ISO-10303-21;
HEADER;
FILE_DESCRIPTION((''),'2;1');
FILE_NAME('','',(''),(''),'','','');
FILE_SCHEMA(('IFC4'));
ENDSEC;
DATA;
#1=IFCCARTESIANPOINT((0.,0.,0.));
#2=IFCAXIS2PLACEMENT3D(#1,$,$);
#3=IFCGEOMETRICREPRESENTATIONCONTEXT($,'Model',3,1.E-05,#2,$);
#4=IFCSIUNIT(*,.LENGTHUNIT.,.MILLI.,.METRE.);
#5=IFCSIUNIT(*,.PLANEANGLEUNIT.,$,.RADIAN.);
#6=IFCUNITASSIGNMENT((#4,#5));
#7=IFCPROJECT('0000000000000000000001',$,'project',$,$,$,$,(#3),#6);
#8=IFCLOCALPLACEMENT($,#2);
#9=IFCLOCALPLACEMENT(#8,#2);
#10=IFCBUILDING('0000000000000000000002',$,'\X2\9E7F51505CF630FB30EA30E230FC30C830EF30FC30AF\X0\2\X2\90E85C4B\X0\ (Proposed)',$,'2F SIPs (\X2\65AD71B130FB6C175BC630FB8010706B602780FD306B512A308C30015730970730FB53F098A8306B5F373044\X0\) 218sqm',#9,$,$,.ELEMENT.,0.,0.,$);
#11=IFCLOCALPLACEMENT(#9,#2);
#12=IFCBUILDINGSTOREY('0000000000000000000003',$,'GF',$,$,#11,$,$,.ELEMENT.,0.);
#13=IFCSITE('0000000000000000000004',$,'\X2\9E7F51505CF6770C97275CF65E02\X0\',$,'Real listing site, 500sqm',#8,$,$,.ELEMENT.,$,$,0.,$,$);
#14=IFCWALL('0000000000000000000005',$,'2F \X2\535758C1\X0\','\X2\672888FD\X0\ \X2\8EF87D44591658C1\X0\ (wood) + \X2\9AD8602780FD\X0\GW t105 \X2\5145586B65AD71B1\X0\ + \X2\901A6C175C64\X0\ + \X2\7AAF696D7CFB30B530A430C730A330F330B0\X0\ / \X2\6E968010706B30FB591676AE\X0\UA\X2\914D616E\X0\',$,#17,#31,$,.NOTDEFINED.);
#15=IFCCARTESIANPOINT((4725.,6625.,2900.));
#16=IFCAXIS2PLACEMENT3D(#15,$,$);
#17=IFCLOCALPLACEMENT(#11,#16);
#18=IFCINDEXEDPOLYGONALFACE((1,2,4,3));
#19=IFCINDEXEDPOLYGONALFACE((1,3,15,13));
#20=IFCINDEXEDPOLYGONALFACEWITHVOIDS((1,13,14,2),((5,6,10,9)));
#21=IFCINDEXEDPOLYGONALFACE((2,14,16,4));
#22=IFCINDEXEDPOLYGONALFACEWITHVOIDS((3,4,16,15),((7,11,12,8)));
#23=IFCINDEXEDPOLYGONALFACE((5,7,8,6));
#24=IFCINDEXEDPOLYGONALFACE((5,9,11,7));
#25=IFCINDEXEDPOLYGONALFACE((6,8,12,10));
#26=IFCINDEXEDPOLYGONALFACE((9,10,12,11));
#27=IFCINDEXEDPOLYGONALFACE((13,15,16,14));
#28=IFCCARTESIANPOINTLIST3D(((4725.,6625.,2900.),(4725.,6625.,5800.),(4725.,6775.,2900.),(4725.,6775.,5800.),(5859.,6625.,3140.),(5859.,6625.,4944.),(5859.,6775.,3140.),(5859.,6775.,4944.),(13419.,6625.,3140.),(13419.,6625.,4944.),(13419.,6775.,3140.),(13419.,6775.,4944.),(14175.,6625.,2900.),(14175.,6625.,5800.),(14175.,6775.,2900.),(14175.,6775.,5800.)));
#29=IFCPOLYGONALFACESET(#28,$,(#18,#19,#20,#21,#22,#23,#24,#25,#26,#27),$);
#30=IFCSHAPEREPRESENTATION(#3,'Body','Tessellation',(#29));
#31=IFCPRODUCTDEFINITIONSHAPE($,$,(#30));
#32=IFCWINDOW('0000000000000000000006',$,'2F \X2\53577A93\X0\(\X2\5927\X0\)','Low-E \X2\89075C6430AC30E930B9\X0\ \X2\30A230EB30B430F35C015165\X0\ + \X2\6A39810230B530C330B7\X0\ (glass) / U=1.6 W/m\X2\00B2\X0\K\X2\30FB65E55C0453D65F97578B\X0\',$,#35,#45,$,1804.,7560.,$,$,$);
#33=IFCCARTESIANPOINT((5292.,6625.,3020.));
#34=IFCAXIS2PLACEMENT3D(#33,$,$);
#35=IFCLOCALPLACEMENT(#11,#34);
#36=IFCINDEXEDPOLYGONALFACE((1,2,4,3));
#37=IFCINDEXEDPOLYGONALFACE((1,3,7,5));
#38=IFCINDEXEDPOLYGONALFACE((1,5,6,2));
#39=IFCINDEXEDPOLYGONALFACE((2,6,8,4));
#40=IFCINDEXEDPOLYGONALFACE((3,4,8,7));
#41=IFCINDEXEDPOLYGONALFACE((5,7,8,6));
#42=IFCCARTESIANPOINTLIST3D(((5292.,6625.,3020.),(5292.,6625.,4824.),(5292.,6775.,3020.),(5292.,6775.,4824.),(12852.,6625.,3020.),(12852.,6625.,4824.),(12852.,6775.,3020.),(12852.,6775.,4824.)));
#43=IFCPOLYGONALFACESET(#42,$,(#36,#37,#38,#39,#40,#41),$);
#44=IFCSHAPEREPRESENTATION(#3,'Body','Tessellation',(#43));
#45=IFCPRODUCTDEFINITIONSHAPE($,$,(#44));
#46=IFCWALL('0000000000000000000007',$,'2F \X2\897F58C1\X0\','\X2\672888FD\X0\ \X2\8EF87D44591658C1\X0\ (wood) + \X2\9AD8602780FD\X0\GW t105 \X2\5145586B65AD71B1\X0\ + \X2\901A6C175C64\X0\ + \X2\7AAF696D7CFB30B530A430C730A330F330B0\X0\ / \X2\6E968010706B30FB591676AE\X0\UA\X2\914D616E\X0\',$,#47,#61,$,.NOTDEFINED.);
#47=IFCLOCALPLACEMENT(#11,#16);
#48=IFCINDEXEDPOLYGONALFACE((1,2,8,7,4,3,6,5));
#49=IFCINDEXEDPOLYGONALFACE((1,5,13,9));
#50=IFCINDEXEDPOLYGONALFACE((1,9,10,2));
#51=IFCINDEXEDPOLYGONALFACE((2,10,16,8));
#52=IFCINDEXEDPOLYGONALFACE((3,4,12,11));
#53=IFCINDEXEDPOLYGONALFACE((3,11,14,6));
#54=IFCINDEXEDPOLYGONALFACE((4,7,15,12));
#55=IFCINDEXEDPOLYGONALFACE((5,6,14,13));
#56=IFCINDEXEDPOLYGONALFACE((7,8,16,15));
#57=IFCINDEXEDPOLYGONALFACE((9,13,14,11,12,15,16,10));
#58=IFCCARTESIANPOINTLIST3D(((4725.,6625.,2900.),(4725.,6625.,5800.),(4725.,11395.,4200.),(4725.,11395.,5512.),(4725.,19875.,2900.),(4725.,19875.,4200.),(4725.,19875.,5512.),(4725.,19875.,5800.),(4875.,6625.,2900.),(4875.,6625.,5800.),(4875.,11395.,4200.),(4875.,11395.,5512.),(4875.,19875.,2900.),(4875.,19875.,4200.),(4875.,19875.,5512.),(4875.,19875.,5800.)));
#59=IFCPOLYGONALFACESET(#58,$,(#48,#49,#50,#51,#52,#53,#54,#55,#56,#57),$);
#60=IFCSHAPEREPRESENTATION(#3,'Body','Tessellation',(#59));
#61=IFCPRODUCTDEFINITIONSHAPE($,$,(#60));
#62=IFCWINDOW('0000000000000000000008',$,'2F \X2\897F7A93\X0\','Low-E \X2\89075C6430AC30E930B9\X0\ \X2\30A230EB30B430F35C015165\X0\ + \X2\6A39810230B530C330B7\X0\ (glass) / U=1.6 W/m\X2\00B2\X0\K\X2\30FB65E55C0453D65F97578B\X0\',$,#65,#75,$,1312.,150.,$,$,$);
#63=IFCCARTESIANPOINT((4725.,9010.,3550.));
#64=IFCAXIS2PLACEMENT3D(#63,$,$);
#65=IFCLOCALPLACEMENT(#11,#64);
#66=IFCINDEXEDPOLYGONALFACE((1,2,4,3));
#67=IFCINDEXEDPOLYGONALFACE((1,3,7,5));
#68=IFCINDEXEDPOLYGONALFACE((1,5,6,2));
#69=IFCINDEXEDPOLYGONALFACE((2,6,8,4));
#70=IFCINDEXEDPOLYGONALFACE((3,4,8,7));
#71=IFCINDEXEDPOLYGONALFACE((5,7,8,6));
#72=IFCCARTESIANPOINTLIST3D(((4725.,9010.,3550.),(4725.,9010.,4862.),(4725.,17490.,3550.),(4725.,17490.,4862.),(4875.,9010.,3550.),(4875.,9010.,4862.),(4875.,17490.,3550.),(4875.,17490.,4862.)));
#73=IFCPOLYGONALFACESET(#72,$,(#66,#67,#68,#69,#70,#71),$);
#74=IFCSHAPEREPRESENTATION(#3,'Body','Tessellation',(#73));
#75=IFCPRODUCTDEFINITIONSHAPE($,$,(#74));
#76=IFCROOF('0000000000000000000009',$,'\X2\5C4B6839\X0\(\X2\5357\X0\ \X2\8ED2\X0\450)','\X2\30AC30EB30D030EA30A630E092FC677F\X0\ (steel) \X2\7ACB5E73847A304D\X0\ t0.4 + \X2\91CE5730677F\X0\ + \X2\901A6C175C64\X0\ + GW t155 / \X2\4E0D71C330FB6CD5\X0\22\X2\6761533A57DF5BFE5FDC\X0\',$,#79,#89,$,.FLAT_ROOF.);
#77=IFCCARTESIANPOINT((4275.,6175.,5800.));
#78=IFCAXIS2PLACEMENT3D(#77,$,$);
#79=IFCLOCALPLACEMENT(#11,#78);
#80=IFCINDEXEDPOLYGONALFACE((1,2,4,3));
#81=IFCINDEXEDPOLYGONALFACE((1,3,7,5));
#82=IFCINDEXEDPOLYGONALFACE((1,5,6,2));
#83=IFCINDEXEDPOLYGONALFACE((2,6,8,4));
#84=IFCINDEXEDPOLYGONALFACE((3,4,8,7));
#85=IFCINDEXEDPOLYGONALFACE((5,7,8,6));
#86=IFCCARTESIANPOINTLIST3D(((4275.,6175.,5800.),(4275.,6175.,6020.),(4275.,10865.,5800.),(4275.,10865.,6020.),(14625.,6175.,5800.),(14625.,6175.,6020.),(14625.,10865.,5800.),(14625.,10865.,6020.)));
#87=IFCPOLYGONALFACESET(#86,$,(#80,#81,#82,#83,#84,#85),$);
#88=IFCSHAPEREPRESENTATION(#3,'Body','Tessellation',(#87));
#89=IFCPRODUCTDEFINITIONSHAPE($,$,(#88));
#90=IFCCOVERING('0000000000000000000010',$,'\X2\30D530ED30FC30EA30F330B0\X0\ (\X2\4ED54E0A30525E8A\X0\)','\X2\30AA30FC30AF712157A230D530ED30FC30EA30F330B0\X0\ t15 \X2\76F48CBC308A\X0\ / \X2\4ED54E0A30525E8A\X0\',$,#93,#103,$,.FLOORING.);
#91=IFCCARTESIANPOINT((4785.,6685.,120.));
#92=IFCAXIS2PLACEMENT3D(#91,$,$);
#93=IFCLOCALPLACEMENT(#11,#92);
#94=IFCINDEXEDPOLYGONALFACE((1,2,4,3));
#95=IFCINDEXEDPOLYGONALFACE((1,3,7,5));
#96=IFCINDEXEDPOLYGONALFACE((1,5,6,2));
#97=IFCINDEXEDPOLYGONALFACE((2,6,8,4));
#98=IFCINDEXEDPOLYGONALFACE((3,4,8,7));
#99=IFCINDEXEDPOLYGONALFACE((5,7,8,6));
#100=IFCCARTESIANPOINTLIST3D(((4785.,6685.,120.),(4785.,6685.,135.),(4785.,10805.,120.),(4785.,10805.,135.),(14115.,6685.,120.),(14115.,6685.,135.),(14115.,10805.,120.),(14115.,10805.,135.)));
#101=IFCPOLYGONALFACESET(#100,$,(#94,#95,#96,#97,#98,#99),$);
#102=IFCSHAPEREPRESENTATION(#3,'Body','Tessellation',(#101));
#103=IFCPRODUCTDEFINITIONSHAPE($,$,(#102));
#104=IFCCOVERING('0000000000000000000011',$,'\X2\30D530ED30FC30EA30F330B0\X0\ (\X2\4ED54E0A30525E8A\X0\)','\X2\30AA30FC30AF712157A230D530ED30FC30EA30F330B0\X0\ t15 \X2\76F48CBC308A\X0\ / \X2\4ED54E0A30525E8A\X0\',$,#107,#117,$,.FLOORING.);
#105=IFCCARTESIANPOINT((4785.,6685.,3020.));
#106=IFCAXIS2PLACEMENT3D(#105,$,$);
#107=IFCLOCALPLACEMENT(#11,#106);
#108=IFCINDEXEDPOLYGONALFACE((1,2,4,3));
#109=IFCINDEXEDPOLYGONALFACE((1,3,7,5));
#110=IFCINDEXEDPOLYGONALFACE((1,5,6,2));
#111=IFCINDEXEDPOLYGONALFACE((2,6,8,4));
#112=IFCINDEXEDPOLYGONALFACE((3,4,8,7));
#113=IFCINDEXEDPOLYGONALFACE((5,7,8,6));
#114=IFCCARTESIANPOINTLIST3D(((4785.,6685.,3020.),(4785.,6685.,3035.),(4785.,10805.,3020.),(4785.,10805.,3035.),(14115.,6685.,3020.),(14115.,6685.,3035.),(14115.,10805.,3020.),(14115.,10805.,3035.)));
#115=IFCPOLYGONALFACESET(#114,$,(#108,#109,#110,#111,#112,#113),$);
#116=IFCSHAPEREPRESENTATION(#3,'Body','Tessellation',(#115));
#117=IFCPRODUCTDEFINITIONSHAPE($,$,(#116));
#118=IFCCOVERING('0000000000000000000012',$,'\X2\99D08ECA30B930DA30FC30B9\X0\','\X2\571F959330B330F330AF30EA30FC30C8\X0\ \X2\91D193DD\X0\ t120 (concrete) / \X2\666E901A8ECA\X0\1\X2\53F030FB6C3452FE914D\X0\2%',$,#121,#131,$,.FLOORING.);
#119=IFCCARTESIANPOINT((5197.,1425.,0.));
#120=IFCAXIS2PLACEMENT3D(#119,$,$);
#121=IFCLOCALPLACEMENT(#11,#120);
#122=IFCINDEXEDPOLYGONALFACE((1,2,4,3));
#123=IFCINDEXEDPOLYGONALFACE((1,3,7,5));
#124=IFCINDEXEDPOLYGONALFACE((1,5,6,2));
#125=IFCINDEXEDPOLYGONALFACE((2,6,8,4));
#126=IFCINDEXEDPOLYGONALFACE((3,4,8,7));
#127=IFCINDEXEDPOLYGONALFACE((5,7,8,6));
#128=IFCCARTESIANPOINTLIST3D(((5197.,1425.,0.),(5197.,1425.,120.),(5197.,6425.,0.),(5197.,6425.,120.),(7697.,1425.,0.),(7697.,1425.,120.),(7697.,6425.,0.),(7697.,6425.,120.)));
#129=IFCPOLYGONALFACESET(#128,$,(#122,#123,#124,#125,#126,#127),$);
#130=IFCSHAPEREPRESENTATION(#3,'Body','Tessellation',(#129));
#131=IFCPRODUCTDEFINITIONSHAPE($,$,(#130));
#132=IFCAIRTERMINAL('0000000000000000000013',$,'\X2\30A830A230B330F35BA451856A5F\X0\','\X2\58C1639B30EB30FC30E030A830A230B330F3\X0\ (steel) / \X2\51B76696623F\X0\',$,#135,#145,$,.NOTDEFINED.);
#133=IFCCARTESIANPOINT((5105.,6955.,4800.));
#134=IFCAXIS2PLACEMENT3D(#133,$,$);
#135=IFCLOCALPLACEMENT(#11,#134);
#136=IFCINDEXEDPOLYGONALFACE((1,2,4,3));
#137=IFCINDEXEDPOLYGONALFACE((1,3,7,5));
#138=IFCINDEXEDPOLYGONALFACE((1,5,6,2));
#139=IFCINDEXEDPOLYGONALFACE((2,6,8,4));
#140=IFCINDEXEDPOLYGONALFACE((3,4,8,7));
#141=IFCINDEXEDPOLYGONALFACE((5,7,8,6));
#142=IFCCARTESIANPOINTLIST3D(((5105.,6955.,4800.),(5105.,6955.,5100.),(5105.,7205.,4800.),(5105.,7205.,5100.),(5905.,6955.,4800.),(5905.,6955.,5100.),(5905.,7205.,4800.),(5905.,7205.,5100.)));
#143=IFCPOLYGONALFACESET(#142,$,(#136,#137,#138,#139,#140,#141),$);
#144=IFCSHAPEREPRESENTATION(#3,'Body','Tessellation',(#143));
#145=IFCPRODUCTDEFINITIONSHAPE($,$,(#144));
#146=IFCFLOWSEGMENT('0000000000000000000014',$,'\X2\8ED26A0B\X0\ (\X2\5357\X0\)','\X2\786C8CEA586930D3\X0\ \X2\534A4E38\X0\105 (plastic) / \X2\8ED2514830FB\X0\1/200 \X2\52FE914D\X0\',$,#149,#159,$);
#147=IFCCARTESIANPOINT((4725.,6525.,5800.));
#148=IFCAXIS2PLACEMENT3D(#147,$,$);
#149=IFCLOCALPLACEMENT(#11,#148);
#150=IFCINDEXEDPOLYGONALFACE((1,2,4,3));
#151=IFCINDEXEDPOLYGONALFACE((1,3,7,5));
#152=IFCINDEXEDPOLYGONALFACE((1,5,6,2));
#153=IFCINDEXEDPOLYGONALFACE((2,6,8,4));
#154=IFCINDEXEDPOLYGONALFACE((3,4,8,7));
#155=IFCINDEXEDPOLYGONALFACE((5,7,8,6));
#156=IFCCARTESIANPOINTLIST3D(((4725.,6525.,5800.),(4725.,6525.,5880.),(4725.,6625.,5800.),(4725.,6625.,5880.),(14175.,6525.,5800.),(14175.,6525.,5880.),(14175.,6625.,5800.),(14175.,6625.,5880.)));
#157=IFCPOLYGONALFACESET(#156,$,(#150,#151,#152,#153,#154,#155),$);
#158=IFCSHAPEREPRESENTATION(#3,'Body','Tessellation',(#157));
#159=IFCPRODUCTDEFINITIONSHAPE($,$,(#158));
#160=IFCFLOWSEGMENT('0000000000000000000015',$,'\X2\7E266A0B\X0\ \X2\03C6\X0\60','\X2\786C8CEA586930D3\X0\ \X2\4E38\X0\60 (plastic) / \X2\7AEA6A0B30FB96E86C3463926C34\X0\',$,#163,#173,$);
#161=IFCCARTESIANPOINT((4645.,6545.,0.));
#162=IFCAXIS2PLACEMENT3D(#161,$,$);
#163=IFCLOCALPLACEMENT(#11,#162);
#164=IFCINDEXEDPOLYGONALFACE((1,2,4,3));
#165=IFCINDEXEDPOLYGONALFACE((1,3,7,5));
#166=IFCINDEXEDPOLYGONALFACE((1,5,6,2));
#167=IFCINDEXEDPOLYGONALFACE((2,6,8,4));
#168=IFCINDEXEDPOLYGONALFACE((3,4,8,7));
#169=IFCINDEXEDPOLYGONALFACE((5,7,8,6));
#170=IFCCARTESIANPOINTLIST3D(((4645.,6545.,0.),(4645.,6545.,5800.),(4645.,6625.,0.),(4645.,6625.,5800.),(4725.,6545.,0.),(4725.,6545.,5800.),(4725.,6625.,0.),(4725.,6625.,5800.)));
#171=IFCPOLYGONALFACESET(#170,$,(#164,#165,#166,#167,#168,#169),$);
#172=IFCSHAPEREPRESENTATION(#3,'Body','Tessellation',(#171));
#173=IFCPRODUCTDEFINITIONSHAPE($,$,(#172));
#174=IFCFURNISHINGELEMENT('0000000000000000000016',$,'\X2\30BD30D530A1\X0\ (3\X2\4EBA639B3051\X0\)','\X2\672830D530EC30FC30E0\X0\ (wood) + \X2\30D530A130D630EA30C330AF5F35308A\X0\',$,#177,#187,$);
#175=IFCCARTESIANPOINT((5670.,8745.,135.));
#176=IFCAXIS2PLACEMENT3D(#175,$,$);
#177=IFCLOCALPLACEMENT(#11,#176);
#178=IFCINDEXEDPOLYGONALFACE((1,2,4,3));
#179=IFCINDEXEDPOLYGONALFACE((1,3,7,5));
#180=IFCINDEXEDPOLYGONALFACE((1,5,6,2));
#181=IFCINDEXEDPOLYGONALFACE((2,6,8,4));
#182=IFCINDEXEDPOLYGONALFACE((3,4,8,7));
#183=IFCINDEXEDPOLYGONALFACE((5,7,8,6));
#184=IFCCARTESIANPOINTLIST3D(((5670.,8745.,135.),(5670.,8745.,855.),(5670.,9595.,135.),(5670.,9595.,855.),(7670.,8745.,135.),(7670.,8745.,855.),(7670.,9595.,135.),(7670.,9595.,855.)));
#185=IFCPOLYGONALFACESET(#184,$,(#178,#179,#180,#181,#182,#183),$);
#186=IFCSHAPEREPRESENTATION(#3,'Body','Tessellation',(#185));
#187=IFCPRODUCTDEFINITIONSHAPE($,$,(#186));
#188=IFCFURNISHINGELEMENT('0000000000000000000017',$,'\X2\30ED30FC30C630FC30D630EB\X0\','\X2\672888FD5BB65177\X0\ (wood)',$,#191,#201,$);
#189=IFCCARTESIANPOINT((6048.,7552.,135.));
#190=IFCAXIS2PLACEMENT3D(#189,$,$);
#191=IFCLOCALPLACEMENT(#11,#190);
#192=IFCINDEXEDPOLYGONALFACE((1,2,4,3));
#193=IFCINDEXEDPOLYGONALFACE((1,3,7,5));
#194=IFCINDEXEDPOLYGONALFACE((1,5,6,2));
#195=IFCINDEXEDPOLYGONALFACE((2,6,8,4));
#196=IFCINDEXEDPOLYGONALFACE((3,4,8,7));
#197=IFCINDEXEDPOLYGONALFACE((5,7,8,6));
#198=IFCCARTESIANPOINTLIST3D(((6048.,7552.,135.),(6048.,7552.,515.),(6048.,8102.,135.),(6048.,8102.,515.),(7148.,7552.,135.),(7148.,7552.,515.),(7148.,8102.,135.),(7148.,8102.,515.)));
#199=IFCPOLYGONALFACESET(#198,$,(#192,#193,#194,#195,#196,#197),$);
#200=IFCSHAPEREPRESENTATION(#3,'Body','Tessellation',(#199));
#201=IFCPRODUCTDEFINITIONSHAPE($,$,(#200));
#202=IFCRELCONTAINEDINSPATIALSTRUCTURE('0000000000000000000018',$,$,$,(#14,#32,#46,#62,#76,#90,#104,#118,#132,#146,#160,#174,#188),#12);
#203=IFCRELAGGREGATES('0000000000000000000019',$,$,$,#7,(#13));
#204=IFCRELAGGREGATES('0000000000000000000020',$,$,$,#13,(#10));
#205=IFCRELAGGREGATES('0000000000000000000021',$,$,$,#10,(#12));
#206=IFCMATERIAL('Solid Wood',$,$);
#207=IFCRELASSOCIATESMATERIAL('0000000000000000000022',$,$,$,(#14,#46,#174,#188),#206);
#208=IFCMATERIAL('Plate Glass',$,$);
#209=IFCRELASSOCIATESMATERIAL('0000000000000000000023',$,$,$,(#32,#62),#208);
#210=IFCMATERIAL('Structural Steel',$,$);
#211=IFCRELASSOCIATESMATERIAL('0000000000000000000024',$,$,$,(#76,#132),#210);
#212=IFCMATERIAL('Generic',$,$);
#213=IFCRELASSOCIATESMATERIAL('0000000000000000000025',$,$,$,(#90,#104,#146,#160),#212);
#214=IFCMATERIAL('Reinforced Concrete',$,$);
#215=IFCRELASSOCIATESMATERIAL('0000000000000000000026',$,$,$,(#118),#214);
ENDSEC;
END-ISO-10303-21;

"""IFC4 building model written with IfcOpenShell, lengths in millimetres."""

from ifc_helpers import new_model, si_unit, frame, frame_2d, origin, place, context, project, spatial, rectangle, extrude, material, element, fill, save


model = new_model("IFC4")

# Units and contexts
model_context = context("Model", 3, precision=1e-05, world=origin())
ifc_project = project(units=[si_unit("LENGTHUNIT", "METRE", prefix="MILLI"), si_unit("PLANEANGLEUNIT", "RADIAN")], contexts=[model_context])

# Site, building, storey
site_placement = place(None, origin())
site = spatial("IfcSite", under=ifc_project, at=site_placement, Name="鹿児島県霧島市", ObjectType="Real listing site, 500sqm", CompositionType="ELEMENT", RefElevation=0.0)
building_placement = place(site_placement, origin())
building = spatial("IfcBuilding", under=site, at=building_placement, Name="鹿児島・リモートワーク2部屋 (Proposed)", ObjectType="2F SIPs (断熱・気密・耐火性能に優れ、地震・台風に強い) 218sqm", CompositionType="ELEMENT", ElevationOfRefHeight=0.0, ElevationOfTerrain=0.0)
storey_placement = place(building_placement, origin())
storey = spatial("IfcBuildingStorey", under=building, at=storey_placement, Name="GF", CompositionType="ELEMENT", Elevation=0.0)

# Shared definitions
ifc_material_1 = material(Name="Solid Wood")

# Shared definitions
ifc_material_2 = material(Name="Reinforced Concrete")

# Shared definitions
ifc_material_3 = material(Name="Plate Glass")

# Walls, openings, windows
wall_1_placement = place(storey_placement, frame((4725.0, 6625.0, 2900.0)))
wall_1 = element("IfcWall", 1, at=wall_1_placement, inside=storey, material=ifc_material_1, Name="2F 南壁", Description="木製 軸組外壁 (wood) + 高性能GW t105 充填断熱 + 通気層 + 窯業系サイディング / 準耐火・外皮UA配慮", PredefinedType="NOTDEFINED", context=model_context, shape_type="SweptSolid", body=[
    extrude(rectangle(XDim=9450.0, YDim=150.0, at=frame_2d((4725.0, 75.0))), frame((4725.0, 6625.0, 2900.0)), (0.0, 0.0, 1.0), 2900.0),
])
opening_1_placement = place(storey_placement, frame((5292.0, 6625.0, 3020.0)))
opening_1 = element("IfcOpeningElement", 2, at=opening_1_placement, cuts=wall_1, PredefinedType="NOTDEFINED", context=model_context, shape_type="SweptSolid", body=[
    extrude(rectangle(XDim=7560.0, YDim=150.0, at=frame_2d((3780.0, 75.0))), frame((5292.0, 6625.0, 3020.0)), (0.0, 0.0, 1.0), 1804.0),
])
window_1_placement = place(storey_placement, frame((5292.0, 6625.0, 3020.0)))
window_1 = element("IfcWindow", 3, at=window_1_placement, inside=storey, material=ifc_material_3, Name="2F 南窓(大)", Description="Low-E 複層ガラス アルゴン封入 + 樹脂サッシ (glass) / U=1.6 W/m²K・日射取得型", OverallHeight=1804.0, OverallWidth=7560.0, context=model_context, shape_type="SweptSolid", body=[
    extrude(rectangle(XDim=7560.0, YDim=150.0, at=frame_2d((3780.0, 75.0))), frame((5292.0, 6625.0, 3020.0)), (0.0, 0.0, 1.0), 1804.0),
])
fill(opening_1, window_1)
wall_2_placement = place(storey_placement, frame((4725.0, 6625.0, 2900.0)))
wall_2 = element("IfcWall", 4, at=wall_2_placement, inside=storey, material=ifc_material_1, Name="2F 西壁", Description="木製 軸組外壁 (wood) + 高性能GW t105 充填断熱 + 通気層 + 窯業系サイディング / 準耐火・外皮UA配慮", PredefinedType="NOTDEFINED", context=model_context, shape_type="SweptSolid", body=[
    extrude(rectangle(XDim=150.0, YDim=13250.0, at=frame_2d((75.0, 6625.0))), frame((4725.0, 6625.0, 2900.0)), (0.0, 0.0, 1.0), 2900.0),
])
opening_2_placement = place(storey_placement, frame((4725.0, 9010.0, 3550.0)))
opening_2 = element("IfcOpeningElement", 5, at=opening_2_placement, cuts=wall_2, PredefinedType="NOTDEFINED", context=model_context, shape_type="SweptSolid", body=[
    extrude(rectangle(XDim=150.0, YDim=8480.0, at=frame_2d((75.0, 4240.0))), frame((4725.0, 9010.0, 3550.0)), (0.0, 0.0, 1.0), 1312.0),
])
window_2_placement = place(storey_placement, frame((4725.0, 9010.0, 3550.0)))
window_2 = element("IfcWindow", 6, at=window_2_placement, inside=storey, material=ifc_material_3, Name="2F 西窓", Description="Low-E 複層ガラス アルゴン封入 + 樹脂サッシ (glass) / U=1.6 W/m²K・日射取得型", OverallHeight=1312.0, OverallWidth=150.0, context=model_context, shape_type="SweptSolid", body=[
    extrude(rectangle(XDim=150.0, YDim=8480.0, at=frame_2d((75.0, 4240.0))), frame((4725.0, 9010.0, 3550.0)), (0.0, 0.0, 1.0), 1312.0),
])
fill(opening_2, window_2)

# Roof
ifc_material_4 = material(Name="Structural Steel")
for number, where, name in (
    (7, (4275.0, 6175.0, 5800.0), "屋根(南 軒450)"),
):
    element("IfcRoof", number, at=place(storey_placement, frame(where)), inside=storey, material=ifc_material_4, Name=name, Description="ガルバリウム鋼板 (steel) 立平葺き t0.4 + 野地板 + 通気層 + GW t155 / 不燃・法22条区域対応", PredefinedType="FLAT_ROOF", context=model_context, shape_type="SweptSolid", body=[
        extrude(rectangle(XDim=10350.0, YDim=4690.0, at=frame_2d((5175.0, 2345.0))), frame((4275.0, 6175.0, 5800.0)), (0.0, 0.0, 1.0), 220.0),
    ])

# Coverings
ifc_material_5 = material(Name="Generic")
covering_1_placement = place(storey_placement, frame((4785.0, 6685.0, 120.0)))
element("IfcCovering", 8, at=covering_1_placement, inside=storey, material=ifc_material_5, Name="フローリング (仕上げ床)", Description="オーク無垢フローリング t15 直貼り / 仕上げ床", PredefinedType="FLOORING", context=model_context, shape_type="SweptSolid", body=[
    extrude(rectangle(XDim=9330.0, YDim=4120.0, at=frame_2d((4665.0, 2060.0))), frame((4785.0, 6685.0, 120.0)), (0.0, 0.0, 1.0), 15.0),
])
covering_2_placement = place(storey_placement, frame((4785.0, 6685.0, 3020.0)))
element("IfcCovering", 9, at=covering_2_placement, inside=storey, material=ifc_material_5, Name="フローリング (仕上げ床)", Description="オーク無垢フローリング t15 直貼り / 仕上げ床", PredefinedType="FLOORING", context=model_context, shape_type="SweptSolid", body=[
    extrude(rectangle(XDim=9330.0, YDim=4120.0, at=frame_2d((4665.0, 2060.0))), frame((4785.0, 6685.0, 3020.0)), (0.0, 0.0, 1.0), 15.0),
])
covering_3_placement = place(storey_placement, frame((5197.0, 1425.0, 0.0)))
element("IfcCovering", 10, at=covering_3_placement, inside=storey, material=ifc_material_2, Name="駐車スペース", Description="土間コンクリート 金鏝 t120 (concrete) / 普通車1台・水勾配2%", PredefinedType="FLOORING", context=model_context, shape_type="SweptSolid", body=[
    extrude(rectangle(XDim=2500.0, YDim=5000.0, at=frame_2d((1250.0, 2500.0))), frame((5197.0, 1425.0, 0.0)), (0.0, 0.0, 1.0), 120.0),
])

# Air terminal
air_terminal_placement = place(storey_placement, frame((5105.0, 6955.0, 4800.0)))
element("IfcAirTerminal", 11, at=air_terminal_placement, inside=storey, material=ifc_material_4, Name="エアコン室内機", Description="壁掛ルームエアコン (steel) / 冷暖房", PredefinedType="NOTDEFINED", context=model_context, shape_type="SweptSolid", body=[
    extrude(rectangle(XDim=800.0, YDim=250.0, at=frame_2d((400.0, 125.0))), frame((5105.0, 6955.0, 4800.0)), (0.0, 0.0, 1.0), 300.0),
])

# Flow segments
flow_segment_1_placement = place(storey_placement, frame((4725.0, 6525.0, 5800.0)))
element("IfcFlowSegment", 12, at=flow_segment_1_placement, inside=storey, material=ifc_material_5, Name="軒樋 (南)", Description="硬質塩ビ 半丸105 (plastic) / 軒先・1/200 勾配", context=model_context, shape_type="SweptSolid", body=[
    extrude(rectangle(XDim=9450.0, YDim=100.0, at=frame_2d((4725.0, 50.0))), frame((4725.0, 6525.0, 5800.0)), (0.0, 0.0, 1.0), 80.0),
])
flow_segment_2_placement = place(storey_placement, frame((4645.0, 6545.0, 0.0)))
element("IfcFlowSegment", 13, at=flow_segment_2_placement, inside=storey, material=ifc_material_5, Name="縦樋 φ60", Description="硬質塩ビ 丸60 (plastic) / 竪樋・雨水排水", context=model_context, shape_type="SweptSolid", body=[
    extrude(rectangle(XDim=80.0, YDim=80.0, at=frame_2d((40.0, 40.0))), frame((4645.0, 6545.0, 0.0)), (0.0, 0.0, 1.0), 5800.0),
])

# Furnishing elements
furnishing_1_placement = place(storey_placement, frame((5670.0, 8745.0, 135.0)))
element("IfcFurnishingElement", 14, at=furnishing_1_placement, inside=storey, material=ifc_material_1, Name="ソファ (3人掛け)", Description="木フレーム (wood) + ファブリック張り", context=model_context, shape_type="SweptSolid", body=[
    extrude(rectangle(XDim=2000.0, YDim=850.0, at=frame_2d((1000.0, 425.0))), frame((5670.0, 8745.0, 135.0)), (0.0, 0.0, 1.0), 720.0),
])
furnishing_2_placement = place(storey_placement, frame((6048.0, 7552.0, 135.0)))
element("IfcFurnishingElement", 15, at=furnishing_2_placement, inside=storey, material=ifc_material_1, Name="ローテーブル", Description="木製家具 (wood)", context=model_context, shape_type="SweptSolid", body=[
    extrude(rectangle(XDim=1100.0, YDim=550.0, at=frame_2d((550.0, 275.0))), frame((6048.0, 7552.0, 135.0)), (0.0, 0.0, 1.0), 380.0),
])

save(model, "model.ifc")
